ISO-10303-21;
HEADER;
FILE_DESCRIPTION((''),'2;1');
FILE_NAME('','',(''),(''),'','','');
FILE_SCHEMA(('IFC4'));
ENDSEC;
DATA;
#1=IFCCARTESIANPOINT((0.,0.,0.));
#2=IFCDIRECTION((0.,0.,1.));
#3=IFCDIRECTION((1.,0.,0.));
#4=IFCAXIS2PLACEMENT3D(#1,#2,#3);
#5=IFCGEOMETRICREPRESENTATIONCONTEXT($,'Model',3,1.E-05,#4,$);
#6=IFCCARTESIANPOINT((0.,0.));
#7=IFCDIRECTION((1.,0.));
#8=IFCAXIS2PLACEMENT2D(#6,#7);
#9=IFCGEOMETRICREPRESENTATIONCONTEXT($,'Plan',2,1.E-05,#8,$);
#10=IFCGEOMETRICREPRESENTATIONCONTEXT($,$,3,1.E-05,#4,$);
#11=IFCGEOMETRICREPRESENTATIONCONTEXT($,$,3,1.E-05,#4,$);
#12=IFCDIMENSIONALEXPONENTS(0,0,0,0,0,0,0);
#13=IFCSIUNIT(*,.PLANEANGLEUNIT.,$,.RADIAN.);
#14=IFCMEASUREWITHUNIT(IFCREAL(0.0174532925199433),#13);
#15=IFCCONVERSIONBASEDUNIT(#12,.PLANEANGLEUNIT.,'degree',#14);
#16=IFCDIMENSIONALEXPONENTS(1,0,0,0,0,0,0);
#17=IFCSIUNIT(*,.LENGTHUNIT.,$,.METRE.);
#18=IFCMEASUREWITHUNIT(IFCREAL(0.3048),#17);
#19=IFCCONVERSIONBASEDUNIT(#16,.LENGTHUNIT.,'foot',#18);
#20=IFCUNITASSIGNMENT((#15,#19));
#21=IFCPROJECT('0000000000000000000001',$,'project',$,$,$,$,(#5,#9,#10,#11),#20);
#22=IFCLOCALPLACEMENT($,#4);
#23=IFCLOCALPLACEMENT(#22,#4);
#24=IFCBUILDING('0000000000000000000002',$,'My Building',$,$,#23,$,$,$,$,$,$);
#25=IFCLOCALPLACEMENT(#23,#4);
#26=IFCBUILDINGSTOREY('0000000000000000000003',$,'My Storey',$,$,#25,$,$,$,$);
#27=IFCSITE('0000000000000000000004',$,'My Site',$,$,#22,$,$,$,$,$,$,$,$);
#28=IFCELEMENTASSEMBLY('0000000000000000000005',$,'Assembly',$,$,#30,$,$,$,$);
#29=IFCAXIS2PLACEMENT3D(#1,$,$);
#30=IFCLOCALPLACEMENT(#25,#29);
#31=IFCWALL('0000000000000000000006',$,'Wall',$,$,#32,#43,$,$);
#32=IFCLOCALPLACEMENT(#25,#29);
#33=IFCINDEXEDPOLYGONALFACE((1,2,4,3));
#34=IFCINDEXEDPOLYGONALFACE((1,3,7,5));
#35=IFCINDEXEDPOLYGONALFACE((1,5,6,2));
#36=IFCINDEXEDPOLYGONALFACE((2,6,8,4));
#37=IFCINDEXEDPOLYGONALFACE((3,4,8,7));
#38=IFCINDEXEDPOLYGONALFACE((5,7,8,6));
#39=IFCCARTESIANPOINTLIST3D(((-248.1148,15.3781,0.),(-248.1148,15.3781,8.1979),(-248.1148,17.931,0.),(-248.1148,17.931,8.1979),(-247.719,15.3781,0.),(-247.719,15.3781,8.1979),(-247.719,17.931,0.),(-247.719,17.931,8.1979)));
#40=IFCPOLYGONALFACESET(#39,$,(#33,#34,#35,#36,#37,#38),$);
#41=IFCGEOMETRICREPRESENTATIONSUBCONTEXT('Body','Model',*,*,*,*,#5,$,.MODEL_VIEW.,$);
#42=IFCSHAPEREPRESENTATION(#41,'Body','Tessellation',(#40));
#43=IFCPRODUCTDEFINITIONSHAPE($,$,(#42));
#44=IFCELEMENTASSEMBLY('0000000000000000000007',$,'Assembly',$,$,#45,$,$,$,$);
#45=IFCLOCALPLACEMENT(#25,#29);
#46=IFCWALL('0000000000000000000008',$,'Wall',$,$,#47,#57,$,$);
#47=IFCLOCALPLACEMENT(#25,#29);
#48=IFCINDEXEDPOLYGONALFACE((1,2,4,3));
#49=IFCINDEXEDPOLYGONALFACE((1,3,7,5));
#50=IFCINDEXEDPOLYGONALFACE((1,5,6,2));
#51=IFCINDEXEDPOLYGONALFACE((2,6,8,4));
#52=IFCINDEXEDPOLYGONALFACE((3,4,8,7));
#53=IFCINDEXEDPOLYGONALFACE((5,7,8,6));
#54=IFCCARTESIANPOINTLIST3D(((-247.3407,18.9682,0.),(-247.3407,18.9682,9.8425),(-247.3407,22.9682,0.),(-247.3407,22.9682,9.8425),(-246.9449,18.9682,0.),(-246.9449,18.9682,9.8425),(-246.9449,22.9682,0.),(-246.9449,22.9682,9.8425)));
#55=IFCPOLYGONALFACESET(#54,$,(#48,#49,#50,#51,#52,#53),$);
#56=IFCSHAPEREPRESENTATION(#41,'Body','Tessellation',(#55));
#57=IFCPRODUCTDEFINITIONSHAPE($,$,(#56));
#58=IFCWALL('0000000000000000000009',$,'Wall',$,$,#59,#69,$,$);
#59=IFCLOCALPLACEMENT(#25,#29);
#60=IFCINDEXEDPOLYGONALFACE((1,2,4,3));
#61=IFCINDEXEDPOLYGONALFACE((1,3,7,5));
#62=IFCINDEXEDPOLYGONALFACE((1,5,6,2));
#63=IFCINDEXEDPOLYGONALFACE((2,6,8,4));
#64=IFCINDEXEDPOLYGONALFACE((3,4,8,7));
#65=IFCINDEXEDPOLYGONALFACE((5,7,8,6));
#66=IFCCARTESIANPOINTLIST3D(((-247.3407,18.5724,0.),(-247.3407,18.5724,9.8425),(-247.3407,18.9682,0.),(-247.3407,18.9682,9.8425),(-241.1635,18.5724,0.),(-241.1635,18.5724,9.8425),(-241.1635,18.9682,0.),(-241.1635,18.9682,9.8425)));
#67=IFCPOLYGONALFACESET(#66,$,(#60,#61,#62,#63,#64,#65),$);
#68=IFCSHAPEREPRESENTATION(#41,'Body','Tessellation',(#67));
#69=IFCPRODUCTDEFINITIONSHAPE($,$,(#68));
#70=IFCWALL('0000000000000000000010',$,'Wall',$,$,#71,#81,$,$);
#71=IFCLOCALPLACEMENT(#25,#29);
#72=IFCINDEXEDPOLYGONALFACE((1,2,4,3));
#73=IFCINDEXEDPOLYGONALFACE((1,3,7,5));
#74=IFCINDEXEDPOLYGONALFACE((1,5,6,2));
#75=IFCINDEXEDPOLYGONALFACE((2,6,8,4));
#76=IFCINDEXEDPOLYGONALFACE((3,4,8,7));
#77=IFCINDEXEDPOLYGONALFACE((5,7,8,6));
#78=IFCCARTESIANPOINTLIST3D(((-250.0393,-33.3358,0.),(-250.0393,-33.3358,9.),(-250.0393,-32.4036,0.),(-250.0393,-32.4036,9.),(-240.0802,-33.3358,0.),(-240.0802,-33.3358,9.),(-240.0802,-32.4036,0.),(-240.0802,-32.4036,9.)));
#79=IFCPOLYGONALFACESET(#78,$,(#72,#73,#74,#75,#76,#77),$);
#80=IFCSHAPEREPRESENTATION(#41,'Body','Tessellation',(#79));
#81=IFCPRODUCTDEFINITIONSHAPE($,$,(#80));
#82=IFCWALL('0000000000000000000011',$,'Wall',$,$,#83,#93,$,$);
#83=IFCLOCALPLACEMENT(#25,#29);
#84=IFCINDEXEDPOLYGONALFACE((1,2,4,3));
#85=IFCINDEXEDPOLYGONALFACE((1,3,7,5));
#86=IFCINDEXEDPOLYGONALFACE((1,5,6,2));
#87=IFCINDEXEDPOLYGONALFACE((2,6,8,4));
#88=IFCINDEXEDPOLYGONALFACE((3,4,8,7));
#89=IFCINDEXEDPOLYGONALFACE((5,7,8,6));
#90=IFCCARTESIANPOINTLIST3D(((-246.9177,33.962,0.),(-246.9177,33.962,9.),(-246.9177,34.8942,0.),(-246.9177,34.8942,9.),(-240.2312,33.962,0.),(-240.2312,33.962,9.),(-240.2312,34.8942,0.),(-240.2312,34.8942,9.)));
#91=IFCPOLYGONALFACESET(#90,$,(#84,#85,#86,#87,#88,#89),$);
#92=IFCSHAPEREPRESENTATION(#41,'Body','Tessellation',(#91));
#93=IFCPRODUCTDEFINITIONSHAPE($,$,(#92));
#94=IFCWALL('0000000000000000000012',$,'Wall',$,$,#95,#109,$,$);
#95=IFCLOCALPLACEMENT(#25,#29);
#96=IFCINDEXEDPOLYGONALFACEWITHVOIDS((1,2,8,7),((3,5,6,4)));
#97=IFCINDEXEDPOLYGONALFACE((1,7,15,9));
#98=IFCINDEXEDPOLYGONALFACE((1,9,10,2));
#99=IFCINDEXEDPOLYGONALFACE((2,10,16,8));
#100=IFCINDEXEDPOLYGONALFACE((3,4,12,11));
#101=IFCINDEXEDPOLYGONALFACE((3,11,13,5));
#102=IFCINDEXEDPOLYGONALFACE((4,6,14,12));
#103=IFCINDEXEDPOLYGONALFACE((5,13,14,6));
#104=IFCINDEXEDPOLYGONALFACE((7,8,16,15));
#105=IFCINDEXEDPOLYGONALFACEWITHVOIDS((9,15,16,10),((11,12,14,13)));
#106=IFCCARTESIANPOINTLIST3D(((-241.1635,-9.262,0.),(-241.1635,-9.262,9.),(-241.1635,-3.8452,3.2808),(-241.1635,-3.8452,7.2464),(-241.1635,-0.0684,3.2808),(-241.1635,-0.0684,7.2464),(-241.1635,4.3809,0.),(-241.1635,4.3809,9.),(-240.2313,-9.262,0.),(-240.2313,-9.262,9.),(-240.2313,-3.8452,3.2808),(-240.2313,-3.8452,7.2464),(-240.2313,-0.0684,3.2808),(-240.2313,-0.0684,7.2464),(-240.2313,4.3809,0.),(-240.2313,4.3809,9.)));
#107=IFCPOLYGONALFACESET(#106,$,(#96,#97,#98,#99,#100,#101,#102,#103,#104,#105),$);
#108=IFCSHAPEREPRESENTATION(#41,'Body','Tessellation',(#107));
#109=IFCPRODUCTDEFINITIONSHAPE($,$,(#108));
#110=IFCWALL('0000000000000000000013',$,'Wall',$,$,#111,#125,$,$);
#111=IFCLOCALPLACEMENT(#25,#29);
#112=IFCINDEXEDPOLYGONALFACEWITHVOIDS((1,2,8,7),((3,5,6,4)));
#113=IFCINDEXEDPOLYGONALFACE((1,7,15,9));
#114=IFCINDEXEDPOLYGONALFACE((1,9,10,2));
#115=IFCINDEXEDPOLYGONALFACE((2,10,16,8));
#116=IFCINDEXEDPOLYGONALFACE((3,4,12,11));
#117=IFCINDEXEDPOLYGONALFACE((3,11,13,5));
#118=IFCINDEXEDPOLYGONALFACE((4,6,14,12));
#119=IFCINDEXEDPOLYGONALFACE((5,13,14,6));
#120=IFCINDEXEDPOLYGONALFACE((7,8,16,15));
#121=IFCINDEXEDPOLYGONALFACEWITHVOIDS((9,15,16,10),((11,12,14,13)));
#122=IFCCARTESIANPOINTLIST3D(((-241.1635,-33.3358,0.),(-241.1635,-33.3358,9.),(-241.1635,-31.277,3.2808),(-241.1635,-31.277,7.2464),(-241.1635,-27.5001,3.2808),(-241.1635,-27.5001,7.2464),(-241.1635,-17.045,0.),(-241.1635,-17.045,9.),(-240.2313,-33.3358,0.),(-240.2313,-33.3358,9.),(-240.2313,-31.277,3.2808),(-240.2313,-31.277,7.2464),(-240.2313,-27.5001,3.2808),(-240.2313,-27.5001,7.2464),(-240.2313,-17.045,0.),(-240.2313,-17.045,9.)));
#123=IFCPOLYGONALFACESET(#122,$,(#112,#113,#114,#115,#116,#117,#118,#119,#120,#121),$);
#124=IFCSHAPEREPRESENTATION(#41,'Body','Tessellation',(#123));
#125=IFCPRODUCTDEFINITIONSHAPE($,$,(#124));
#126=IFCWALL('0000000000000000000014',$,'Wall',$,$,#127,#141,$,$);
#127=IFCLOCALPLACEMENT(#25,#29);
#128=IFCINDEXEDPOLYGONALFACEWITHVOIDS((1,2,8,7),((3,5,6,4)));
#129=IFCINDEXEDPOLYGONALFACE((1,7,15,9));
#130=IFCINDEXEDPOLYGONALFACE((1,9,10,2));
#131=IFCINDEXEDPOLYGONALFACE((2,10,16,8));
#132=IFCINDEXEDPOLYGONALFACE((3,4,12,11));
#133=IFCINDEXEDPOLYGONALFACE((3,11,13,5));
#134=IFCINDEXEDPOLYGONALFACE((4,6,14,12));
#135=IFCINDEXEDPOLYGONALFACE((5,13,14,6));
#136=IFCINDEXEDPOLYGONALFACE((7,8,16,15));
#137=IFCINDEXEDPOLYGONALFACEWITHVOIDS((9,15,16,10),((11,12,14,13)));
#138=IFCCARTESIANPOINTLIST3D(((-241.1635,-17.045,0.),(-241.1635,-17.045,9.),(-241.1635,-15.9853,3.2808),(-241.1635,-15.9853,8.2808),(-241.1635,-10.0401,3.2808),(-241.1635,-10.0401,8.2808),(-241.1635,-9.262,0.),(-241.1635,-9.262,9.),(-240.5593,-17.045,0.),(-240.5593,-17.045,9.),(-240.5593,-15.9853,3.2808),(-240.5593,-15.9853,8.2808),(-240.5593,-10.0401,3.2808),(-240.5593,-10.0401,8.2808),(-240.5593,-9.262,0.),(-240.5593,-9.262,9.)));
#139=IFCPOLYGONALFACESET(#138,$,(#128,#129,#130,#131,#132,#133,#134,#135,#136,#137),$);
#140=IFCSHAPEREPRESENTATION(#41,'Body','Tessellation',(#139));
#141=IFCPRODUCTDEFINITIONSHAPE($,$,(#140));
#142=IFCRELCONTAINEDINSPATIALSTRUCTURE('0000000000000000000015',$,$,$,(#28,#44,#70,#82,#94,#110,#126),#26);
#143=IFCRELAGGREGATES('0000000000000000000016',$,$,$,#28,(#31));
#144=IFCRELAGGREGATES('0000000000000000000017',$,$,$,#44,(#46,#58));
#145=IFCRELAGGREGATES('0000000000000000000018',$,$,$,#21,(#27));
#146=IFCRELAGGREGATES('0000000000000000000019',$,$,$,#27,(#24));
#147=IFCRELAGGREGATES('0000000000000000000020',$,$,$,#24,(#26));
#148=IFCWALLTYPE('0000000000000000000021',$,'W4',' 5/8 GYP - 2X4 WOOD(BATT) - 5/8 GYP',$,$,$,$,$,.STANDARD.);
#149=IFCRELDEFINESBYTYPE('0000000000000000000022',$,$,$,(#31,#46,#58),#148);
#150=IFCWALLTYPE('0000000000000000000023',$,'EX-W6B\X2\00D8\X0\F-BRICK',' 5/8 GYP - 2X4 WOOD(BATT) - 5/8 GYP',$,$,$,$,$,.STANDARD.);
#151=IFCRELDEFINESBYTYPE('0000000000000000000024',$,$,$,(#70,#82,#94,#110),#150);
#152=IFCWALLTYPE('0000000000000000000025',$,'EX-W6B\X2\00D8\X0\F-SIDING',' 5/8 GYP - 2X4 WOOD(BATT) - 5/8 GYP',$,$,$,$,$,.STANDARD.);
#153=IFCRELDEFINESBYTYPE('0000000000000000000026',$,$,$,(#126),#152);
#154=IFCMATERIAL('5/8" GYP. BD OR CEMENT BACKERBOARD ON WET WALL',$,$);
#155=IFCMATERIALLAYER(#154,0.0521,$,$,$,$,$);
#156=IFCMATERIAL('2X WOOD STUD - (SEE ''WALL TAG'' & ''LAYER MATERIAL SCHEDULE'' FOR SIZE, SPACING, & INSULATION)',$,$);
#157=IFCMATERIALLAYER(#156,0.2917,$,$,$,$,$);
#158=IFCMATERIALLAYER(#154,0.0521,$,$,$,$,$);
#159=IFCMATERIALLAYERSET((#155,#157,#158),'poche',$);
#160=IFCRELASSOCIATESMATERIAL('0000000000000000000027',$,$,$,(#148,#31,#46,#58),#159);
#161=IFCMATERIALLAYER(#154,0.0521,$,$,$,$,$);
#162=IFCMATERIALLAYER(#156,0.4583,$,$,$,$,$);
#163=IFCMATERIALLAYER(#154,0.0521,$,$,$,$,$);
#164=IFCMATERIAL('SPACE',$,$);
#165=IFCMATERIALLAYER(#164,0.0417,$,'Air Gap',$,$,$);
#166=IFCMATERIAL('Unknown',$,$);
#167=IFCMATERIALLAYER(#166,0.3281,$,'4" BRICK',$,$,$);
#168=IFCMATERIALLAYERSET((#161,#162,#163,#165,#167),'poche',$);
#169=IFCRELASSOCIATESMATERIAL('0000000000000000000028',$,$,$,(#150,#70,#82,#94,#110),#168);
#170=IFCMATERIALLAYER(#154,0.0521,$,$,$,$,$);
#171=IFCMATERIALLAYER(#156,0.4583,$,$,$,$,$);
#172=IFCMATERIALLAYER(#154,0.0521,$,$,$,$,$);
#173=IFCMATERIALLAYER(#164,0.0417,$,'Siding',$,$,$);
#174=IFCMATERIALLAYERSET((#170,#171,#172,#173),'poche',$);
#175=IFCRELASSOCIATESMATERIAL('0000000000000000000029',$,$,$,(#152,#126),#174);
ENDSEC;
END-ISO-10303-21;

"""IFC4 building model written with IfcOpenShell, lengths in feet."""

from ifc_helpers import new_model, entity, si_unit, converted_unit, frame, origin_with_axes, origin_2d_with_axis, place, context, subcontext, project, spatial, line, indexed_curve, outline, extrude, source, transform, mapped, material, layer, layer_set, layer_usage, type_object, element, aggregate, save


model = new_model("IFC4")

# Units and contexts
model_context = context("Model", 3, precision=1e-05, world=origin_with_axes())
plan_context = context("Plan", 2, precision=1e-05, world=origin_2d_with_axis())
context_of_model_1 = context(None, 3, precision=1e-05, world=origin_with_axes())
context_of_model_2 = context(None, 3, precision=1e-05, world=origin_with_axes())
body_context_1 = subcontext(model_context, "Body", "Model", "MODEL_VIEW")
ifc_project = project(units=[converted_unit("PLANEANGLEUNIT", "degree", entity("IfcReal", 0.0174532925199433), si_unit("PLANEANGLEUNIT", "RADIAN"), dimensions=[0, 0, 0, 0, 0, 0, 0]), converted_unit("LENGTHUNIT", "foot", entity("IfcReal", 0.3048), si_unit("LENGTHUNIT", "METRE"), dimensions=[1, 0, 0, 0, 0, 0, 0])], contexts=[model_context, plan_context, context_of_model_1, context_of_model_2])

# Site, building, storey
site_placement = place(None, origin_with_axes())
site = spatial("IfcSite", under=ifc_project, at=site_placement, Name="My Site")
building_placement = place(site_placement, origin_with_axes())
building = spatial("IfcBuilding", under=site, at=building_placement, Name="My Building")
storey_placement = place(building_placement, origin_with_axes())
storey = spatial("IfcBuildingStorey", under=building, at=storey_placement, Name="My Storey")

# Element assembly, wall
assembly_1_placement = place(storey_placement, origin_with_axes())
assembly_1 = element("IfcElementAssembly", 1, at=assembly_1_placement, inside=storey, Name="Assembly")
ifc_material_1 = material(Name="5/8\" GYP. BD OR CEMENT BACKERBOARD ON WET WALL")
ifc_layer_1 = layer(ifc_material_1, 0.0521)
ifc_material_2 = material(Name="2X WOOD STUD - (SEE 'WALL TAG' & 'LAYER MATERIAL SCHEDULE' FOR SIZE, SPACING, & INSULATION)")
ifc_layer_2 = layer(ifc_material_2, 0.2917)
ifc_layer_3 = layer(ifc_material_1, 0.0521)
ifc_layer_set_1 = layer_set([ifc_layer_1, ifc_layer_2, ifc_layer_3], Name="poche")
ifc_layer_usage_1 = layer_usage(ifc_layer_set_1, "AXIS2", "POSITIVE", 0.0)
wall_type_1 = type_object("IfcWallType", Name="W4", Description=" 5/8 GYP - 2X4 WOOD(BATT) - 5/8 GYP", PredefinedType="STANDARD", material=ifc_layer_set_1)
wall_1_placement = place(assembly_1_placement, frame((-248.1148, 17.931, 0.0), z_axis=(0.0, 0.0, 1.0), x_axis=(0.0, -1.0, 0.0)))
wall_1 = element("IfcWall", 2, at=wall_1_placement, type_object=wall_type_1, material=ifc_layer_usage_1, Name="Wall", context=body_context_1, shape_type="SweptSolid", body=[
    extrude(outline(indexed_curve([(0.0, 0.0), (0.0, 0.3958), (2.5529, 0.3958), (2.5529, 0.0), (0.0, 0.0)], self_intersect=False)), origin_with_axes(), (0.0, 0.0, 1.0), 8.1979),
])
aggregate(assembly_1, [wall_1])

# Element assembly, walls
assembly_2_placement = place(storey_placement, origin_with_axes())
assembly_2 = element("IfcElementAssembly", 3, at=assembly_2_placement, inside=storey, Name="Assembly")
ifc_layer_usage_2 = layer_usage(ifc_layer_set_1, "AXIS2", "POSITIVE", 0.0)
wall_2_placement = place(assembly_2_placement, frame((-246.9449, 18.9682, 0.0), z_axis=(0.0, 0.0, 1.0), x_axis=(0.0, 1.0, 0.0)))
wall_2 = element("IfcWall", 4, at=wall_2_placement, type_object=wall_type_1, material=ifc_layer_usage_2, Name="Wall", context=body_context_1, shape_type="SweptSolid", body=[
    extrude(outline(indexed_curve([(0.0, 0.0), (0.0, 0.3958), (4.0, 0.3958), (4.0, 0.0), (0.0, 0.0)], self_intersect=False)), origin_with_axes(), (0.0, 0.0, 1.0), 9.8425),
])
ifc_layer_usage_3 = layer_usage(ifc_layer_set_1, "AXIS2", "POSITIVE", 0.0)
wall_3_placement = place(assembly_2_placement, frame((-241.1635, 18.9682, 0.0), z_axis=(0.0, 0.0, 1.0), x_axis=(-1.0, 0.0, 0.0)))
wall_3 = element("IfcWall", 5, at=wall_3_placement, type_object=wall_type_1, material=ifc_layer_usage_3, Name="Wall", context=body_context_1, shape_type="SweptSolid", body=[
    extrude(outline(indexed_curve([(0.0, 0.0), (0.0, 0.3958), (6.1772, 0.3958), (6.1772, 0.0), (0.0, 0.0)], self_intersect=False)), origin_with_axes(), (0.0, 0.0, 1.0), 9.8425),
])

# Walls
ifc_layer_4 = layer(ifc_material_1, 0.0521)
ifc_layer_5 = layer(ifc_material_2, 0.4583)
ifc_layer_6 = layer(ifc_material_1, 0.0521)
ifc_material_3 = material(Name="SPACE")
ifc_layer_7 = layer(ifc_material_3, 0.0417, Name="Air Gap")
ifc_material_4 = material(Name="Unknown")
ifc_layer_8 = layer(ifc_material_4, 0.3281, Name="4\" BRICK")
ifc_layer_set_2 = layer_set([ifc_layer_4, ifc_layer_5, ifc_layer_6, ifc_layer_7, ifc_layer_8], Name="poche")
ifc_layer_usage_4 = layer_usage(ifc_layer_set_2, "AXIS2", "POSITIVE", 0.0)
wall_type_2 = type_object("IfcWallType", Name="EX-W6BØF-BRICK", Description=" 5/8 GYP - 2X4 WOOD(BATT) - 5/8 GYP", PredefinedType="STANDARD", material=ifc_layer_set_2)
wall_4_placement = place(storey_placement, frame((-240.0802, -32.4036, 0.0), z_axis=(0.0, 0.0, 1.0), x_axis=(-1.0, 0.0, 0.0)))
element("IfcWall", 6, at=wall_4_placement, inside=storey, type_object=wall_type_2, material=ifc_layer_usage_4, Name="Wall", context=body_context_1, shape_type="SweptSolid", body=[
    extrude(outline(indexed_curve([(0.0, 0.0), (0.0, 0.9323), (9.9591, 0.9323), (9.9591, 0.0), (0.0, 0.0)], self_intersect=False)), origin_with_axes(), (0.0, 0.0, 1.0), 9.0),
])
ifc_layer_usage_5 = layer_usage(ifc_layer_set_2, "AXIS2", "POSITIVE", 0.0)
wall_5_placement = place(storey_placement, frame((-246.9177, 33.962, 0.0), z_axis=(0.0, 0.0, 1.0), x_axis=(1.0, 0.0, 0.0)))
element("IfcWall", 7, at=wall_5_placement, inside=storey, type_object=wall_type_2, material=ifc_layer_usage_5, Name="Wall", context=body_context_1, shape_type="SweptSolid", body=[
    extrude(outline(indexed_curve([(0.0, 0.0), (0.0, 0.9323), (6.6865, 0.9323), (6.6865, 0.0), (0.0, 0.0)], self_intersect=False)), origin_with_axes(), (0.0, 0.0, 1.0), 9.0),
])

# Walls, openings
ifc_layer_usage_6 = layer_usage(ifc_layer_set_2, "AXIS2", "POSITIVE", 0.0)
wall_6_placement = place(storey_placement, frame((-241.1635, 4.3809, 0.0), z_axis=(0.0, 0.0, 1.0), x_axis=(0.0, -1.0, 0.0)))
wall_6 = element("IfcWall", 8, at=wall_6_placement, inside=storey, type_object=wall_type_2, material=ifc_layer_usage_6, Name="Wall", context=body_context_1, shape_type="SweptSolid", body=[
    extrude(outline(indexed_curve([(0.0, 0.0), (0.0, 0.9323), (13.6429, 0.9323), (13.6429, 0.0), (0.0, 0.0)], self_intersect=False)), origin_with_axes(), (0.0, 0.0, 1.0), 9.0),
])
shared_shape_1 = source(origin_with_axes(), body_context_1, "Body", "SweptSolid", [
    extrude(outline(indexed_curve([(0.0, 0.0), (3.7769, 0.0), (3.7769, 3.9656), (0.0, 3.9656)], segments=[line(1, 2, 3, 4, 1)])), frame((0.0, -0.3281, 0.0), z_axis=(0.0, -1.0, 0.0), x_axis=(1.0, 0.0, 0.0)), (0.0, 0.0, -1.0), 1.5884),
])
opening_1_placement = place(wall_6_placement, frame((4.4492, 0.0, 3.2808), z_axis=(0.0, 0.0, 1.0), x_axis=(1.0, 0.0, 0.0)))
element("IfcOpeningElement", 9, at=opening_1_placement, cuts=wall_6, PredefinedType="OPENING", context=body_context_1, shape_type="MappedRepresentation", body=[
    mapped(shared_shape_1, transform((0.0, 0.0, 0.0), x_axis=(1.0, 0.0, 0.0), y_axis=(0.0, 1.0, 0.0), z_axis=(0.0, 0.0, 1.0), scale=1.0)),
])
ifc_layer_usage_7 = layer_usage(ifc_layer_set_2, "AXIS2", "POSITIVE", 0.0)
wall_7_placement = place(storey_placement, frame((-241.1635, -17.045, 0.0), z_axis=(0.0, 0.0, 1.0), x_axis=(0.0, -1.0, 0.0)))
wall_7 = element("IfcWall", 10, at=wall_7_placement, inside=storey, type_object=wall_type_2, material=ifc_layer_usage_7, Name="Wall", context=body_context_1, shape_type="SweptSolid", body=[
    extrude(outline(indexed_curve([(0.0, 0.0), (0.0, 0.9323), (16.2908, 0.9323), (16.2908, 0.0), (0.0, 0.0)], self_intersect=False)), origin_with_axes(), (0.0, 0.0, 1.0), 9.0),
])
opening_2_placement = place(wall_7_placement, frame((10.4551, 0.0, 3.2808), z_axis=(0.0, 0.0, 1.0), x_axis=(1.0, 0.0, 0.0)))
element("IfcOpeningElement", 11, at=opening_2_placement, cuts=wall_7, PredefinedType="OPENING", context=body_context_1, shape_type="MappedRepresentation", body=[
    mapped(shared_shape_1, transform((0.0, 0.0, 0.0), x_axis=(1.0, 0.0, 0.0), y_axis=(0.0, 1.0, 0.0), z_axis=(0.0, 0.0, 1.0), scale=1.0)),
])
ifc_layer_9 = layer(ifc_material_1, 0.0521)
ifc_layer_10 = layer(ifc_material_2, 0.4583)
ifc_layer_11 = layer(ifc_material_1, 0.0521)
ifc_layer_12 = layer(ifc_material_3, 0.0417, Name="Siding")
ifc_layer_set_3 = layer_set([ifc_layer_9, ifc_layer_10, ifc_layer_11, ifc_layer_12], Name="poche")
ifc_layer_usage_8 = layer_usage(ifc_layer_set_3, "AXIS2", "POSITIVE", 0.0)
wall_type_3 = type_object("IfcWallType", Name="EX-W6BØF-SIDING", Description=" 5/8 GYP - 2X4 WOOD(BATT) - 5/8 GYP", PredefinedType="STANDARD", material=ifc_layer_set_3)
wall_8_placement = place(storey_placement, frame((-241.1635, -9.262, 0.0), z_axis=(0.0, 0.0, 1.0), x_axis=(0.0, -1.0, 0.0)))
wall_8 = element("IfcWall", 12, at=wall_8_placement, inside=storey, type_object=wall_type_3, material=ifc_layer_usage_8, Name="Wall", context=body_context_1, shape_type="SweptSolid", body=[
    extrude(outline(indexed_curve([(0.0, 0.0), (0.0, 0.6042), (7.783, 0.6042), (7.783, 0.0), (0.0, 0.0)], self_intersect=False)), origin_with_axes(), (0.0, 0.0, 1.0), 9.0),
])
shared_shape_2 = source(origin_with_axes(), body_context_1, "Body", "SweptSolid", [
    extrude(outline(indexed_curve([(0.0, 0.0), (5.9453, 0.0), (5.9453, 5.0), (0.0, 5.0)], segments=[line(1, 2, 3, 4, 1)])), frame((0.0, -0.3281, 0.0), z_axis=(0.0, -1.0, 0.0), x_axis=(1.0, 0.0, 0.0)), (0.0, 0.0, -1.0), 1.2603),
])
opening_3_placement = place(wall_8_placement, frame((0.7781, 0.0, 3.2808), z_axis=(0.0, 0.0, 1.0), x_axis=(1.0, 0.0, 0.0)))
element("IfcOpeningElement", 13, at=opening_3_placement, cuts=wall_8, PredefinedType="OPENING", context=body_context_1, shape_type="MappedRepresentation", body=[
    mapped(shared_shape_2, transform((0.0, 0.0, 0.0), x_axis=(1.0, 0.0, 0.0), y_axis=(0.0, 1.0, 0.0), z_axis=(0.0, 0.0, 1.0), scale=1.0)),
])

aggregate(assembly_2, [wall_2, wall_3])

save(model, "model.ifc")
